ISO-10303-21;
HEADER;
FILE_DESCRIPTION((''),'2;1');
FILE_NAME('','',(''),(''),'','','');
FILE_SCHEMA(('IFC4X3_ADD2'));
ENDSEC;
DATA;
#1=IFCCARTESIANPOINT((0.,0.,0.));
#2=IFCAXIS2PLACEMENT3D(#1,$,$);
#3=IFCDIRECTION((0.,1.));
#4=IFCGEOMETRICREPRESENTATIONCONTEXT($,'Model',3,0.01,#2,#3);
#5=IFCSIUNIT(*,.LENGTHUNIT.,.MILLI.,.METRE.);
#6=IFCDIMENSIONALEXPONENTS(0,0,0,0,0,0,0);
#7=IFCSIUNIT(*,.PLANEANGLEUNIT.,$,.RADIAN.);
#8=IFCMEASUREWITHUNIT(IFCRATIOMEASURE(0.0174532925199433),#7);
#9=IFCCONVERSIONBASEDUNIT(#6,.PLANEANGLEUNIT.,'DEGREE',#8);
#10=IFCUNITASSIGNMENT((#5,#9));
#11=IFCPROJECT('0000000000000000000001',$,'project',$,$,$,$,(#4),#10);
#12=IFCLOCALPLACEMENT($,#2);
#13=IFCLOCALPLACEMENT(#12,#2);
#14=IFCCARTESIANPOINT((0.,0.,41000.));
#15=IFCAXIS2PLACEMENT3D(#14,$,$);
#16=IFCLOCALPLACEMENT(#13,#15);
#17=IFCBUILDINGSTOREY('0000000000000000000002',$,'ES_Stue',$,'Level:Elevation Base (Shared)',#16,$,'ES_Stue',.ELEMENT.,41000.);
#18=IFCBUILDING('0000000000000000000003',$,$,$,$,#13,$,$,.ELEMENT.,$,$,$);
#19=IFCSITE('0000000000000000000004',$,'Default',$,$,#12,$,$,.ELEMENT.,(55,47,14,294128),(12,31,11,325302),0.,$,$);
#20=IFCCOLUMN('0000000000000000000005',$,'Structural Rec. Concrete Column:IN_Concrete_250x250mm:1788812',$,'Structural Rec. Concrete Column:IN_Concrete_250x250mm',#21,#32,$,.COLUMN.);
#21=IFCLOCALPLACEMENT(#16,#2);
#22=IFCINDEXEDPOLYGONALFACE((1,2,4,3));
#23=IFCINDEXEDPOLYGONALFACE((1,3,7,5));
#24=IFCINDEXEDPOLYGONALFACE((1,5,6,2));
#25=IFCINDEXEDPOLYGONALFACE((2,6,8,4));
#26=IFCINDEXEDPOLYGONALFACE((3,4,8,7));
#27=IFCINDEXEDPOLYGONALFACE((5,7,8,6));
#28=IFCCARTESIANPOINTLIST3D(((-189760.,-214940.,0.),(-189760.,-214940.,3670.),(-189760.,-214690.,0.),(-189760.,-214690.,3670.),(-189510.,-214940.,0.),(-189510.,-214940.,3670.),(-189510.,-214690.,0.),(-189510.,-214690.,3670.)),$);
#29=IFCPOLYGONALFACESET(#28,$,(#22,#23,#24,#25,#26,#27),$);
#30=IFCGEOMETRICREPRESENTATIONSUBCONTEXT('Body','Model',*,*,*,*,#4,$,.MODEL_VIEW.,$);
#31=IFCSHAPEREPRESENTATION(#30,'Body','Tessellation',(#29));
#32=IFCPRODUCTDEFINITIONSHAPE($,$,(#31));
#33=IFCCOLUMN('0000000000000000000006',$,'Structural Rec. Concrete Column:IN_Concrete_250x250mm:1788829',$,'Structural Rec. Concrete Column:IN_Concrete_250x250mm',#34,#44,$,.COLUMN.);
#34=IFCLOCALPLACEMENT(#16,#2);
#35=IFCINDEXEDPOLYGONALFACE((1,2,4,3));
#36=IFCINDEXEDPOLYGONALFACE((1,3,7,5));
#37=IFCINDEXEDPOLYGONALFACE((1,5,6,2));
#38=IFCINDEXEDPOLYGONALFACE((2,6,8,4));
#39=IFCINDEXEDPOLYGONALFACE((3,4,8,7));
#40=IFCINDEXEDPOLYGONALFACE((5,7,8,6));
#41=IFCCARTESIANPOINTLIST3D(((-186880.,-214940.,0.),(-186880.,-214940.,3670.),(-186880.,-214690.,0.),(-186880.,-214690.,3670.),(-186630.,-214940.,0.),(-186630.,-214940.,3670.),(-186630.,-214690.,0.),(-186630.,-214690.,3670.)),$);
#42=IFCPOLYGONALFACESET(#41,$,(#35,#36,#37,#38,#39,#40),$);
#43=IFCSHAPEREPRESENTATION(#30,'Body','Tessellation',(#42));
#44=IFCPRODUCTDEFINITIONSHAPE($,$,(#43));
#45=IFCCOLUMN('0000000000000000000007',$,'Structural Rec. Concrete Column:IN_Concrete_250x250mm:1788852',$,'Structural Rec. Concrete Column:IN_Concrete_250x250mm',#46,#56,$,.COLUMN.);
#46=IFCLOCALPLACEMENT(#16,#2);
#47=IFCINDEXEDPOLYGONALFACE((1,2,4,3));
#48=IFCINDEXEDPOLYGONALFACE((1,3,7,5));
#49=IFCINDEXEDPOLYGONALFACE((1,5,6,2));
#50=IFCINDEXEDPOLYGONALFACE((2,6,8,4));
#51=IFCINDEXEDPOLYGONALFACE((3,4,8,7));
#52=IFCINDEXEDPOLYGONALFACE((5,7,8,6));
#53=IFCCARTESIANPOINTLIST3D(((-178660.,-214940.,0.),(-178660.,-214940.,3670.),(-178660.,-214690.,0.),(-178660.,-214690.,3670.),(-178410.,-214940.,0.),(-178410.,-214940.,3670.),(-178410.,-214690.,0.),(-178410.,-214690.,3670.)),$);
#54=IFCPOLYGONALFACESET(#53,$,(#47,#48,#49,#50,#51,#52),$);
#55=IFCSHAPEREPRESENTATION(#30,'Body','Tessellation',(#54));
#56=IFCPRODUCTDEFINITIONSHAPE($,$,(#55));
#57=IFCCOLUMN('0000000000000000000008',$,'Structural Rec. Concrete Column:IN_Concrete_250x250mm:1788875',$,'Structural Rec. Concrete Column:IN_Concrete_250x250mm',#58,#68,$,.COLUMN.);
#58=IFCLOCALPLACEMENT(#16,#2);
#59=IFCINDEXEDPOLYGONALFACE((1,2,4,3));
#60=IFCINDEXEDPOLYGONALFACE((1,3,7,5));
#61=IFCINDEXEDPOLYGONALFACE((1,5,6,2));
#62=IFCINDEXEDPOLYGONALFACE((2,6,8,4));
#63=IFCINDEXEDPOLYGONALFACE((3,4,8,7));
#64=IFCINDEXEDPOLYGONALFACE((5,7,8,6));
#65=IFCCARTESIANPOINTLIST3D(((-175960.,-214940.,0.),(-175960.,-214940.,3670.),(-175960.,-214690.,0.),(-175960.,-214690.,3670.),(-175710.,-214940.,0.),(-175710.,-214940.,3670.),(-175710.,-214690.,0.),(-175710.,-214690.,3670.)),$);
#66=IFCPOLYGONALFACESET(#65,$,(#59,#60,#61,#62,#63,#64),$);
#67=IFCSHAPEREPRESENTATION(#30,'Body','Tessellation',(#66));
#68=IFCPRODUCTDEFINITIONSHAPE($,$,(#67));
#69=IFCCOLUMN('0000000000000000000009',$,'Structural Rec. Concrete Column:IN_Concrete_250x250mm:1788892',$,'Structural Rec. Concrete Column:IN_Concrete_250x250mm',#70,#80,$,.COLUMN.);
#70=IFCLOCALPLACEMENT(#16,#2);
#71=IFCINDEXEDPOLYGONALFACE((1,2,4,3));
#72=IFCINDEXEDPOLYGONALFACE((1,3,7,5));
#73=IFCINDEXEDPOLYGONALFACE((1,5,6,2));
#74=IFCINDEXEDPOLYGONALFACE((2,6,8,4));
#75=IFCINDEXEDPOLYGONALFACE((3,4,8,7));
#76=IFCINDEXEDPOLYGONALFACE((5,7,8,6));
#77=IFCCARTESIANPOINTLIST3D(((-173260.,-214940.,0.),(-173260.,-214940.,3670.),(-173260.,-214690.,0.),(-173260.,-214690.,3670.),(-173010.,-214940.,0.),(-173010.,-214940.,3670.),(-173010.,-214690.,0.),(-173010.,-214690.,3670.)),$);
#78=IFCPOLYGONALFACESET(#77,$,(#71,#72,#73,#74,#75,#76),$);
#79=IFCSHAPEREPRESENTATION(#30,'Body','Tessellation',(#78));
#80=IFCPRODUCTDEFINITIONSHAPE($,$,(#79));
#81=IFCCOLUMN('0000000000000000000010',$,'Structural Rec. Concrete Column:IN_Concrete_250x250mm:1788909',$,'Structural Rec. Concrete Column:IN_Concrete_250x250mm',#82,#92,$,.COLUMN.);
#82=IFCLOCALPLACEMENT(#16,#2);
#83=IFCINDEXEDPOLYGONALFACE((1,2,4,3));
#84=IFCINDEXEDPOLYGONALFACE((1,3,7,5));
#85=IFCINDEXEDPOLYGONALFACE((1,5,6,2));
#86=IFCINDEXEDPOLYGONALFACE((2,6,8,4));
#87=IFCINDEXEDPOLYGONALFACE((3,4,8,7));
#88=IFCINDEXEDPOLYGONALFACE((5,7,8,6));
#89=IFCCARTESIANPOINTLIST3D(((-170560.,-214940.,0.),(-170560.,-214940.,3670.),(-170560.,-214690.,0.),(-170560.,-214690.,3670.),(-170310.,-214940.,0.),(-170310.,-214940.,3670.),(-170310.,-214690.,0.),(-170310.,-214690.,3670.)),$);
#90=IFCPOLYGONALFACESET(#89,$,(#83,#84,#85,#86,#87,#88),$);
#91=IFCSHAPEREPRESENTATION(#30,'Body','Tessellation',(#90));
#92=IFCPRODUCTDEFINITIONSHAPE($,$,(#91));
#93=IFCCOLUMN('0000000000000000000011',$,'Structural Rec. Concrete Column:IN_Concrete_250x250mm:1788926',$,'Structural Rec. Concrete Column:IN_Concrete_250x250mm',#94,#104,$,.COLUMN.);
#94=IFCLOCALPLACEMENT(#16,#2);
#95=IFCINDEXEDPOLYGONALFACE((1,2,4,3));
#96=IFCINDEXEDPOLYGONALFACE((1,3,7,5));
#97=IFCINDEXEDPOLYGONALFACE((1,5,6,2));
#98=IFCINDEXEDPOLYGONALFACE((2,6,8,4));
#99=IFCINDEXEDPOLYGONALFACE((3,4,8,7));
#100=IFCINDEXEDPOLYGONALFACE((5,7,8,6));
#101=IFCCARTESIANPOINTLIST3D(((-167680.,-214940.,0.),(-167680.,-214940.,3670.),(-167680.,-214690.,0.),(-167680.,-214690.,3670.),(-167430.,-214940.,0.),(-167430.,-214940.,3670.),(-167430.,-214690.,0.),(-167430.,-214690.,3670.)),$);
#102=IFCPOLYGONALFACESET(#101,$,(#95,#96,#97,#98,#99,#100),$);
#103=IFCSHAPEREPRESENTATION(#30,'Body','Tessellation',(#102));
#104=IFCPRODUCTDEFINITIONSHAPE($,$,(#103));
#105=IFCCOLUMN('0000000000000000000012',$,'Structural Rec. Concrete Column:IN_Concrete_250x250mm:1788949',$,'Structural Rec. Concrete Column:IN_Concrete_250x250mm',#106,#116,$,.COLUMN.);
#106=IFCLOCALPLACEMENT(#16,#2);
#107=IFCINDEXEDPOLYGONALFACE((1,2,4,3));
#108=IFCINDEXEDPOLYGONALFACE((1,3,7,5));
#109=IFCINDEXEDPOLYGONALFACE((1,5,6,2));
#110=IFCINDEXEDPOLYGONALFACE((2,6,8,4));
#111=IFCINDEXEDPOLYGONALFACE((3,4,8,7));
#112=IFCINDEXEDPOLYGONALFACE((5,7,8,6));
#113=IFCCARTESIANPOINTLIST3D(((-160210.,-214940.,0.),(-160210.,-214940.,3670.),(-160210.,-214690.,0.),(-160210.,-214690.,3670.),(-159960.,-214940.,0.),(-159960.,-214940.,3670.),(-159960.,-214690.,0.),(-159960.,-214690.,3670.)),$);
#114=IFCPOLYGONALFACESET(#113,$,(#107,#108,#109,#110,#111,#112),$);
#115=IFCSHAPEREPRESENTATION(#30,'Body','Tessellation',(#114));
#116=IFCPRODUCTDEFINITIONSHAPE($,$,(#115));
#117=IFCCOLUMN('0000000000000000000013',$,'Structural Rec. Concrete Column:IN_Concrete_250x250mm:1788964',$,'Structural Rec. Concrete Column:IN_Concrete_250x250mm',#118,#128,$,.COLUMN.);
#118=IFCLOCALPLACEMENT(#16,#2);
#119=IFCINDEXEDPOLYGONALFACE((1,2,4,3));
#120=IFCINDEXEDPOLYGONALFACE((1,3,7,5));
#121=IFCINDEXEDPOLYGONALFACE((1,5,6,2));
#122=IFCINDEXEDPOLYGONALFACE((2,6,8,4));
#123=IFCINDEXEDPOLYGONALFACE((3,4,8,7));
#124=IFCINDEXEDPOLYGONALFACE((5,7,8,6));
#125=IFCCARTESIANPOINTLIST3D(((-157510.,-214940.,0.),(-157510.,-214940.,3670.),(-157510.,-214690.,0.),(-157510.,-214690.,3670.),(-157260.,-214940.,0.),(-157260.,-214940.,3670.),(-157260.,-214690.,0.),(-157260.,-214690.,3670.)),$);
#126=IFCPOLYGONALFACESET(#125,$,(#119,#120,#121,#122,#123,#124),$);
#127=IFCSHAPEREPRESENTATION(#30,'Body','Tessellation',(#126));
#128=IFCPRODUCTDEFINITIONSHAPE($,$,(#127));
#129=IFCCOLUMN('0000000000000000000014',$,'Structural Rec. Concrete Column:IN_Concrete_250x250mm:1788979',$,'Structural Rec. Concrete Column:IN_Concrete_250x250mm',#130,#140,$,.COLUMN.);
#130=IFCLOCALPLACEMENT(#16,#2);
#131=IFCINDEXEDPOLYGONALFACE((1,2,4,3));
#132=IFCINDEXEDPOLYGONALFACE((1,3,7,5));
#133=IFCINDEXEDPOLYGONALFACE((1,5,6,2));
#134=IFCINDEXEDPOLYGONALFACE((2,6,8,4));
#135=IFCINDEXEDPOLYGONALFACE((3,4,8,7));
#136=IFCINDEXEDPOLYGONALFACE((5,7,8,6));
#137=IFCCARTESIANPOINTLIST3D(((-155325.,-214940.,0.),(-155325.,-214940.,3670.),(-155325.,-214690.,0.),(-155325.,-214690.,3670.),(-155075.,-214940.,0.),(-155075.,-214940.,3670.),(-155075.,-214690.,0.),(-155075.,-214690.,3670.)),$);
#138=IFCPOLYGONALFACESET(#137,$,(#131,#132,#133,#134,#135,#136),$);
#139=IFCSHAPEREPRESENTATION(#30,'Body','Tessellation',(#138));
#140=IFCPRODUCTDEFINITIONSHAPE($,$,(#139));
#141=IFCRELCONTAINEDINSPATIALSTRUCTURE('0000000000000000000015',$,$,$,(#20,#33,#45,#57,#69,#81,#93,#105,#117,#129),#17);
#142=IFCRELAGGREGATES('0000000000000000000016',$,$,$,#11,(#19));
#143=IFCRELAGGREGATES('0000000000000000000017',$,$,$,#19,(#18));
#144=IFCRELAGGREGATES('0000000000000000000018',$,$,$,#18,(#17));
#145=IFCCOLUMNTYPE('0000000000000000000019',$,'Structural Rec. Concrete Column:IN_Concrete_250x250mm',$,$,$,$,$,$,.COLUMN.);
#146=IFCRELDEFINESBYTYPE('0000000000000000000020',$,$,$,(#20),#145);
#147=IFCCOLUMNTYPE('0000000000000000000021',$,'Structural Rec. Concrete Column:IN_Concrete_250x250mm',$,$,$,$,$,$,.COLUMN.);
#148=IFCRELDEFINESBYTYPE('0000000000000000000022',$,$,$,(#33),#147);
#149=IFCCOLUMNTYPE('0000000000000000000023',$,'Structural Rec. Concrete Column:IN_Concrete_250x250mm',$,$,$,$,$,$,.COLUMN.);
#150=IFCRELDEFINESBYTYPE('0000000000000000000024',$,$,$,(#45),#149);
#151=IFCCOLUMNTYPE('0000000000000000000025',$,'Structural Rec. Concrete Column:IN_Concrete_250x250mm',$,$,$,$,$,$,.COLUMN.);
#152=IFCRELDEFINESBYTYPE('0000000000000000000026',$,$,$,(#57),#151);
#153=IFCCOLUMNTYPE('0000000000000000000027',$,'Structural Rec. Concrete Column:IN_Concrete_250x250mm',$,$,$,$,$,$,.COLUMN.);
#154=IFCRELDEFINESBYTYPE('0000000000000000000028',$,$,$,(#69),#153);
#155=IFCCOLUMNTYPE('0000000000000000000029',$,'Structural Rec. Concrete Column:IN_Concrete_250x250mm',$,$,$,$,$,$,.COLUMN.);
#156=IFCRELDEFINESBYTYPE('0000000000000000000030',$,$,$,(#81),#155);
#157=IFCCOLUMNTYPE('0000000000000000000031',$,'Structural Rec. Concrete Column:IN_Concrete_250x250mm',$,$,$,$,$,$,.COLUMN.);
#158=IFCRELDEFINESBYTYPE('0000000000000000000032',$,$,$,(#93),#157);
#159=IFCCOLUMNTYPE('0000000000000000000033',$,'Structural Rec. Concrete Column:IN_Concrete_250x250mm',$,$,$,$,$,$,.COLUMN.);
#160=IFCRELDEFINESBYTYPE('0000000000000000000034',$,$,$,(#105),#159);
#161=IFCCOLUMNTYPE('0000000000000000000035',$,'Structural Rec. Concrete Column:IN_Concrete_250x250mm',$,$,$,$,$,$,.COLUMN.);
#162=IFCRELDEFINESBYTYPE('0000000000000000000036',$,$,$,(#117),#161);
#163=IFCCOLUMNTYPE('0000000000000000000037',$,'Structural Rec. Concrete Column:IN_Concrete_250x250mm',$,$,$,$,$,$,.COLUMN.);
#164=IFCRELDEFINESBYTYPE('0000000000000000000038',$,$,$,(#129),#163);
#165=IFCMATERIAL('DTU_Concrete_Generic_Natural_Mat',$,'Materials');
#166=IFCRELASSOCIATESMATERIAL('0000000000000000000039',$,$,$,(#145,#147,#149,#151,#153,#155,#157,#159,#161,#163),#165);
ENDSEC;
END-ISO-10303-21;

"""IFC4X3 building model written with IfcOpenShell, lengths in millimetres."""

from ifc_helpers import new_model, entity, si_unit, converted_unit, direction, frame, frame_2d, origin, origin_2d_with_axis, place, context, subcontext, project, spatial, rectangle, extrude, source, transform, mapped, material, material_profile, profile_set, type_object, type_shapes, element, save


model = new_model("IFC4X3")

# Units and contexts
model_context = context("Model", 3, precision=0.01, world=origin(), true_north=direction((0.0, 1.0)))
body_context = subcontext(model_context, "Body", "Model", "MODEL_VIEW")
ifc_project = project(units=[si_unit("LENGTHUNIT", "METRE", prefix="MILLI"), converted_unit("PLANEANGLEUNIT", "DEGREE", entity("IfcRatioMeasure", 0.0174532925199433), si_unit("PLANEANGLEUNIT", "RADIAN"), dimensions=[0, 0, 0, 0, 0, 0, 0])], contexts=[model_context])

# Site, building, storey
site_placement = place(None, origin())
site = spatial("IfcSite", under=ifc_project, at=site_placement, Name="Default", CompositionType="ELEMENT", RefLatitude=(55, 47, 14, 294128), RefLongitude=(12, 31, 11, 325302), RefElevation=0.0)
building_placement = place(site_placement, origin())
building = spatial("IfcBuilding", under=site, at=building_placement, CompositionType="ELEMENT")
storey_placement = place(building_placement, frame((0.0, 0.0, 41000.0)))
storey = spatial("IfcBuildingStorey", under=building, at=storey_placement, Name="ES_Stue", ObjectType="Level:Elevation Base (Shared)", LongName="ES_Stue", CompositionType="ELEMENT", Elevation=41000.0)

# Columns
ifc_material = material(Name="DTU_Concrete_Generic_Natural_Mat", Category="Materials")
ifc_material_profile_1 = material_profile(ifc_material, rectangle(XDim=250.0, YDim=250.0, at=origin_2d_with_axis()), Name="IN_Concrete_250x250mm")
ifc_profile_set_1 = profile_set([ifc_material_profile_1], Name="IN_Concrete_250x250mm")
column_type_1 = type_object("IfcColumnType", Name="Structural Rec. Concrete Column:IN_Concrete_250x250mm", PredefinedType="COLUMN", material=ifc_profile_set_1)
shared_shape_1 = source(origin(), body_context, "Body", "SweptSolid", [
    extrude(rectangle(XDim=250.0, YDim=250.0, at=origin_2d_with_axis()), frame((-189635.0, -214815.0, 41000.0), z_axis=(0.0, 0.0, 1.0), x_axis=(0.0, -1.0, 0.0)), (0.0, 0.0, 1.0), 3670.0),
])
type_shapes(column_type_1, [shared_shape_1])
column_1_placement = place(storey_placement, frame((0.0, 0.0, -41000.0)))
element("IfcColumn", 1, at=column_1_placement, inside=storey, type_object=column_type_1, Name="Structural Rec. Concrete Column:IN_Concrete_250x250mm:1788812", ObjectType="Structural Rec. Concrete Column:IN_Concrete_250x250mm", PredefinedType="COLUMN", context=body_context, shape_type="MappedRepresentation", body=[
    mapped(shared_shape_1, transform((0.0, 0.0, 0.0), scale=1.0)),
])
column_type_2 = type_object("IfcColumnType", Name="Structural Rec. Concrete Column:IN_Concrete_250x250mm", PredefinedType="COLUMN", material=ifc_profile_set_1)
shared_shape_2 = source(origin(), body_context, "Body", "SweptSolid", [
    extrude(rectangle(XDim=250.0, YDim=250.0, at=origin_2d_with_axis()), frame((-186755.0, -214815.0, 41000.0), z_axis=(0.0, 0.0, 1.0), x_axis=(0.0, -1.0, 0.0)), (0.0, 0.0, 1.0), 3670.0),
])
type_shapes(column_type_2, [shared_shape_2])
column_2_placement = place(storey_placement, frame((0.0, 0.0, -41000.0)))
element("IfcColumn", 2, at=column_2_placement, inside=storey, type_object=column_type_2, Name="Structural Rec. Concrete Column:IN_Concrete_250x250mm:1788829", ObjectType="Structural Rec. Concrete Column:IN_Concrete_250x250mm", PredefinedType="COLUMN", context=body_context, shape_type="MappedRepresentation", body=[
    mapped(shared_shape_2, transform((0.0, 0.0, 0.0), scale=1.0)),
])
column_type_3 = type_object("IfcColumnType", Name="Structural Rec. Concrete Column:IN_Concrete_250x250mm", PredefinedType="COLUMN", material=ifc_profile_set_1)
shared_shape_3 = source(origin(), body_context, "Body", "SweptSolid", [
    extrude(rectangle(XDim=250.0, YDim=250.0, at=origin_2d_with_axis()), frame((-178535.0, -214815.0, 41000.0), z_axis=(0.0, 0.0, 1.0), x_axis=(0.0, -1.0, 0.0)), (0.0, 0.0, 1.0), 3670.0),
])
type_shapes(column_type_3, [shared_shape_3])
column_3_placement = place(storey_placement, frame((0.0, 0.0, -41000.0)))
element("IfcColumn", 3, at=column_3_placement, inside=storey, type_object=column_type_3, Name="Structural Rec. Concrete Column:IN_Concrete_250x250mm:1788852", ObjectType="Structural Rec. Concrete Column:IN_Concrete_250x250mm", PredefinedType="COLUMN", context=body_context, shape_type="MappedRepresentation", body=[
    mapped(shared_shape_3, transform((0.0, 0.0, 0.0), scale=1.0)),
])
column_type_4 = type_object("IfcColumnType", Name="Structural Rec. Concrete Column:IN_Concrete_250x250mm", PredefinedType="COLUMN", material=ifc_profile_set_1)
shared_shape_4 = source(origin(), body_context, "Body", "SweptSolid", [
    extrude(rectangle(XDim=250.0, YDim=250.0, at=origin_2d_with_axis()), frame((-175835.0, -214815.0, 41000.0), z_axis=(0.0, 0.0, 1.0), x_axis=(0.0, -1.0, 0.0)), (0.0, 0.0, 1.0), 3670.0),
])
type_shapes(column_type_4, [shared_shape_4])
column_4_placement = place(storey_placement, frame((0.0, 0.0, -41000.0)))
element("IfcColumn", 4, at=column_4_placement, inside=storey, type_object=column_type_4, Name="Structural Rec. Concrete Column:IN_Concrete_250x250mm:1788875", ObjectType="Structural Rec. Concrete Column:IN_Concrete_250x250mm", PredefinedType="COLUMN", context=body_context, shape_type="MappedRepresentation", body=[
    mapped(shared_shape_4, transform((0.0, 0.0, 0.0), scale=1.0)),
])
column_type_5 = type_object("IfcColumnType", Name="Structural Rec. Concrete Column:IN_Concrete_250x250mm", PredefinedType="COLUMN", material=ifc_profile_set_1)
shared_shape_5 = source(origin(), body_context, "Body", "SweptSolid", [
    extrude(rectangle(XDim=250.0, YDim=250.0, at=origin_2d_with_axis()), frame((-173135.0, -214815.0, 41000.0), z_axis=(0.0, 0.0, 1.0), x_axis=(0.0, -1.0, 0.0)), (0.0, 0.0, 1.0), 3670.0),
])
type_shapes(column_type_5, [shared_shape_5])
column_5_placement = place(storey_placement, frame((0.0, 0.0, -41000.0)))
element("IfcColumn", 5, at=column_5_placement, inside=storey, type_object=column_type_5, Name="Structural Rec. Concrete Column:IN_Concrete_250x250mm:1788892", ObjectType="Structural Rec. Concrete Column:IN_Concrete_250x250mm", PredefinedType="COLUMN", context=body_context, shape_type="MappedRepresentation", body=[
    mapped(shared_shape_5, transform((0.0, 0.0, 0.0), scale=1.0)),
])
column_type_6 = type_object("IfcColumnType", Name="Structural Rec. Concrete Column:IN_Concrete_250x250mm", PredefinedType="COLUMN", material=ifc_profile_set_1)
shared_shape_6 = source(origin(), body_context, "Body", "SweptSolid", [
    extrude(rectangle(XDim=250.0, YDim=250.0, at=origin_2d_with_axis()), frame((-170435.0, -214815.0, 41000.0), z_axis=(0.0, 0.0, 1.0), x_axis=(0.0, -1.0, 0.0)), (0.0, 0.0, 1.0), 3670.0),
])
type_shapes(column_type_6, [shared_shape_6])
column_6_placement = place(storey_placement, frame((0.0, 0.0, -41000.0)))
element("IfcColumn", 6, at=column_6_placement, inside=storey, type_object=column_type_6, Name="Structural Rec. Concrete Column:IN_Concrete_250x250mm:1788909", ObjectType="Structural Rec. Concrete Column:IN_Concrete_250x250mm", PredefinedType="COLUMN", context=body_context, shape_type="MappedRepresentation", body=[
    mapped(shared_shape_6, transform((0.0, 0.0, 0.0), scale=1.0)),
])
column_type_7 = type_object("IfcColumnType", Name="Structural Rec. Concrete Column:IN_Concrete_250x250mm", PredefinedType="COLUMN", material=ifc_profile_set_1)
shared_shape_7 = source(origin(), body_context, "Body", "SweptSolid", [
    extrude(rectangle(XDim=250.0, YDim=250.0, at=origin_2d_with_axis()), frame((-167555.0, -214815.0, 41000.0), z_axis=(0.0, 0.0, 1.0), x_axis=(0.0, -1.0, 0.0)), (0.0, 0.0, 1.0), 3670.0),
])
type_shapes(column_type_7, [shared_shape_7])
column_7_placement = place(storey_placement, frame((0.0, 0.0, -41000.0)))
element("IfcColumn", 7, at=column_7_placement, inside=storey, type_object=column_type_7, Name="Structural Rec. Concrete Column:IN_Concrete_250x250mm:1788926", ObjectType="Structural Rec. Concrete Column:IN_Concrete_250x250mm", PredefinedType="COLUMN", context=body_context, shape_type="MappedRepresentation", body=[
    mapped(shared_shape_7, transform((0.0, 0.0, 0.0), scale=1.0)),
])
column_type_8 = type_object("IfcColumnType", Name="Structural Rec. Concrete Column:IN_Concrete_250x250mm", PredefinedType="COLUMN", material=ifc_profile_set_1)
shared_shape_8 = source(origin(), body_context, "Body", "SweptSolid", [
    extrude(rectangle(XDim=250.0, YDim=250.0, at=origin_2d_with_axis()), frame((-160085.0, -214815.0, 41000.0), z_axis=(0.0, 0.0, 1.0), x_axis=(0.0, -1.0, 0.0)), (0.0, 0.0, 1.0), 3670.0),
])
type_shapes(column_type_8, [shared_shape_8])
column_8_placement = place(storey_placement, frame((0.0, 0.0, -41000.0)))
element("IfcColumn", 8, at=column_8_placement, inside=storey, type_object=column_type_8, Name="Structural Rec. Concrete Column:IN_Concrete_250x250mm:1788949", ObjectType="Structural Rec. Concrete Column:IN_Concrete_250x250mm", PredefinedType="COLUMN", context=body_context, shape_type="MappedRepresentation", body=[
    mapped(shared_shape_8, transform((0.0, 0.0, 0.0), scale=1.0)),
])
column_type_9 = type_object("IfcColumnType", Name="Structural Rec. Concrete Column:IN_Concrete_250x250mm", PredefinedType="COLUMN", material=ifc_profile_set_1)
shared_shape_9 = source(origin(), body_context, "Body", "SweptSolid", [
    extrude(rectangle(XDim=250.0, YDim=250.0, at=origin_2d_with_axis()), frame((-157385.0, -214815.0, 41000.0), z_axis=(0.0, 0.0, 1.0), x_axis=(0.0, -1.0, 0.0)), (0.0, 0.0, 1.0), 3670.0),
])
type_shapes(column_type_9, [shared_shape_9])
column_9_placement = place(storey_placement, frame((0.0, 0.0, -41000.0)))
element("IfcColumn", 9, at=column_9_placement, inside=storey, type_object=column_type_9, Name="Structural Rec. Concrete Column:IN_Concrete_250x250mm:1788964", ObjectType="Structural Rec. Concrete Column:IN_Concrete_250x250mm", PredefinedType="COLUMN", context=body_context, shape_type="MappedRepresentation", body=[
    mapped(shared_shape_9, transform((0.0, 0.0, 0.0), scale=1.0)),
])
column_type_10 = type_object("IfcColumnType", Name="Structural Rec. Concrete Column:IN_Concrete_250x250mm", PredefinedType="COLUMN", material=ifc_profile_set_1)
shared_shape_10 = source(origin(), body_context, "Body", "SweptSolid", [
    extrude(rectangle(XDim=250.0, YDim=250.0, at=frame_2d((0.0, 0.0), x_axis=(1.0, 0.0))), frame((-155200.0, -214815.0, 41000.0), z_axis=(0.0, 0.0, 1.0), x_axis=(0.0, -1.0, 0.0)), (0.0, 0.0, 1.0), 3670.0),
])
type_shapes(column_type_10, [shared_shape_10])
column_10_placement = place(storey_placement, frame((0.0, 0.0, -41000.0)))
element("IfcColumn", 10, at=column_10_placement, inside=storey, type_object=column_type_10, Name="Structural Rec. Concrete Column:IN_Concrete_250x250mm:1788979", ObjectType="Structural Rec. Concrete Column:IN_Concrete_250x250mm", PredefinedType="COLUMN", context=body_context, shape_type="MappedRepresentation", body=[
    mapped(shared_shape_10, transform((0.0, 0.0, 0.0), scale=1.0)),
])

save(model, "model.ifc")
